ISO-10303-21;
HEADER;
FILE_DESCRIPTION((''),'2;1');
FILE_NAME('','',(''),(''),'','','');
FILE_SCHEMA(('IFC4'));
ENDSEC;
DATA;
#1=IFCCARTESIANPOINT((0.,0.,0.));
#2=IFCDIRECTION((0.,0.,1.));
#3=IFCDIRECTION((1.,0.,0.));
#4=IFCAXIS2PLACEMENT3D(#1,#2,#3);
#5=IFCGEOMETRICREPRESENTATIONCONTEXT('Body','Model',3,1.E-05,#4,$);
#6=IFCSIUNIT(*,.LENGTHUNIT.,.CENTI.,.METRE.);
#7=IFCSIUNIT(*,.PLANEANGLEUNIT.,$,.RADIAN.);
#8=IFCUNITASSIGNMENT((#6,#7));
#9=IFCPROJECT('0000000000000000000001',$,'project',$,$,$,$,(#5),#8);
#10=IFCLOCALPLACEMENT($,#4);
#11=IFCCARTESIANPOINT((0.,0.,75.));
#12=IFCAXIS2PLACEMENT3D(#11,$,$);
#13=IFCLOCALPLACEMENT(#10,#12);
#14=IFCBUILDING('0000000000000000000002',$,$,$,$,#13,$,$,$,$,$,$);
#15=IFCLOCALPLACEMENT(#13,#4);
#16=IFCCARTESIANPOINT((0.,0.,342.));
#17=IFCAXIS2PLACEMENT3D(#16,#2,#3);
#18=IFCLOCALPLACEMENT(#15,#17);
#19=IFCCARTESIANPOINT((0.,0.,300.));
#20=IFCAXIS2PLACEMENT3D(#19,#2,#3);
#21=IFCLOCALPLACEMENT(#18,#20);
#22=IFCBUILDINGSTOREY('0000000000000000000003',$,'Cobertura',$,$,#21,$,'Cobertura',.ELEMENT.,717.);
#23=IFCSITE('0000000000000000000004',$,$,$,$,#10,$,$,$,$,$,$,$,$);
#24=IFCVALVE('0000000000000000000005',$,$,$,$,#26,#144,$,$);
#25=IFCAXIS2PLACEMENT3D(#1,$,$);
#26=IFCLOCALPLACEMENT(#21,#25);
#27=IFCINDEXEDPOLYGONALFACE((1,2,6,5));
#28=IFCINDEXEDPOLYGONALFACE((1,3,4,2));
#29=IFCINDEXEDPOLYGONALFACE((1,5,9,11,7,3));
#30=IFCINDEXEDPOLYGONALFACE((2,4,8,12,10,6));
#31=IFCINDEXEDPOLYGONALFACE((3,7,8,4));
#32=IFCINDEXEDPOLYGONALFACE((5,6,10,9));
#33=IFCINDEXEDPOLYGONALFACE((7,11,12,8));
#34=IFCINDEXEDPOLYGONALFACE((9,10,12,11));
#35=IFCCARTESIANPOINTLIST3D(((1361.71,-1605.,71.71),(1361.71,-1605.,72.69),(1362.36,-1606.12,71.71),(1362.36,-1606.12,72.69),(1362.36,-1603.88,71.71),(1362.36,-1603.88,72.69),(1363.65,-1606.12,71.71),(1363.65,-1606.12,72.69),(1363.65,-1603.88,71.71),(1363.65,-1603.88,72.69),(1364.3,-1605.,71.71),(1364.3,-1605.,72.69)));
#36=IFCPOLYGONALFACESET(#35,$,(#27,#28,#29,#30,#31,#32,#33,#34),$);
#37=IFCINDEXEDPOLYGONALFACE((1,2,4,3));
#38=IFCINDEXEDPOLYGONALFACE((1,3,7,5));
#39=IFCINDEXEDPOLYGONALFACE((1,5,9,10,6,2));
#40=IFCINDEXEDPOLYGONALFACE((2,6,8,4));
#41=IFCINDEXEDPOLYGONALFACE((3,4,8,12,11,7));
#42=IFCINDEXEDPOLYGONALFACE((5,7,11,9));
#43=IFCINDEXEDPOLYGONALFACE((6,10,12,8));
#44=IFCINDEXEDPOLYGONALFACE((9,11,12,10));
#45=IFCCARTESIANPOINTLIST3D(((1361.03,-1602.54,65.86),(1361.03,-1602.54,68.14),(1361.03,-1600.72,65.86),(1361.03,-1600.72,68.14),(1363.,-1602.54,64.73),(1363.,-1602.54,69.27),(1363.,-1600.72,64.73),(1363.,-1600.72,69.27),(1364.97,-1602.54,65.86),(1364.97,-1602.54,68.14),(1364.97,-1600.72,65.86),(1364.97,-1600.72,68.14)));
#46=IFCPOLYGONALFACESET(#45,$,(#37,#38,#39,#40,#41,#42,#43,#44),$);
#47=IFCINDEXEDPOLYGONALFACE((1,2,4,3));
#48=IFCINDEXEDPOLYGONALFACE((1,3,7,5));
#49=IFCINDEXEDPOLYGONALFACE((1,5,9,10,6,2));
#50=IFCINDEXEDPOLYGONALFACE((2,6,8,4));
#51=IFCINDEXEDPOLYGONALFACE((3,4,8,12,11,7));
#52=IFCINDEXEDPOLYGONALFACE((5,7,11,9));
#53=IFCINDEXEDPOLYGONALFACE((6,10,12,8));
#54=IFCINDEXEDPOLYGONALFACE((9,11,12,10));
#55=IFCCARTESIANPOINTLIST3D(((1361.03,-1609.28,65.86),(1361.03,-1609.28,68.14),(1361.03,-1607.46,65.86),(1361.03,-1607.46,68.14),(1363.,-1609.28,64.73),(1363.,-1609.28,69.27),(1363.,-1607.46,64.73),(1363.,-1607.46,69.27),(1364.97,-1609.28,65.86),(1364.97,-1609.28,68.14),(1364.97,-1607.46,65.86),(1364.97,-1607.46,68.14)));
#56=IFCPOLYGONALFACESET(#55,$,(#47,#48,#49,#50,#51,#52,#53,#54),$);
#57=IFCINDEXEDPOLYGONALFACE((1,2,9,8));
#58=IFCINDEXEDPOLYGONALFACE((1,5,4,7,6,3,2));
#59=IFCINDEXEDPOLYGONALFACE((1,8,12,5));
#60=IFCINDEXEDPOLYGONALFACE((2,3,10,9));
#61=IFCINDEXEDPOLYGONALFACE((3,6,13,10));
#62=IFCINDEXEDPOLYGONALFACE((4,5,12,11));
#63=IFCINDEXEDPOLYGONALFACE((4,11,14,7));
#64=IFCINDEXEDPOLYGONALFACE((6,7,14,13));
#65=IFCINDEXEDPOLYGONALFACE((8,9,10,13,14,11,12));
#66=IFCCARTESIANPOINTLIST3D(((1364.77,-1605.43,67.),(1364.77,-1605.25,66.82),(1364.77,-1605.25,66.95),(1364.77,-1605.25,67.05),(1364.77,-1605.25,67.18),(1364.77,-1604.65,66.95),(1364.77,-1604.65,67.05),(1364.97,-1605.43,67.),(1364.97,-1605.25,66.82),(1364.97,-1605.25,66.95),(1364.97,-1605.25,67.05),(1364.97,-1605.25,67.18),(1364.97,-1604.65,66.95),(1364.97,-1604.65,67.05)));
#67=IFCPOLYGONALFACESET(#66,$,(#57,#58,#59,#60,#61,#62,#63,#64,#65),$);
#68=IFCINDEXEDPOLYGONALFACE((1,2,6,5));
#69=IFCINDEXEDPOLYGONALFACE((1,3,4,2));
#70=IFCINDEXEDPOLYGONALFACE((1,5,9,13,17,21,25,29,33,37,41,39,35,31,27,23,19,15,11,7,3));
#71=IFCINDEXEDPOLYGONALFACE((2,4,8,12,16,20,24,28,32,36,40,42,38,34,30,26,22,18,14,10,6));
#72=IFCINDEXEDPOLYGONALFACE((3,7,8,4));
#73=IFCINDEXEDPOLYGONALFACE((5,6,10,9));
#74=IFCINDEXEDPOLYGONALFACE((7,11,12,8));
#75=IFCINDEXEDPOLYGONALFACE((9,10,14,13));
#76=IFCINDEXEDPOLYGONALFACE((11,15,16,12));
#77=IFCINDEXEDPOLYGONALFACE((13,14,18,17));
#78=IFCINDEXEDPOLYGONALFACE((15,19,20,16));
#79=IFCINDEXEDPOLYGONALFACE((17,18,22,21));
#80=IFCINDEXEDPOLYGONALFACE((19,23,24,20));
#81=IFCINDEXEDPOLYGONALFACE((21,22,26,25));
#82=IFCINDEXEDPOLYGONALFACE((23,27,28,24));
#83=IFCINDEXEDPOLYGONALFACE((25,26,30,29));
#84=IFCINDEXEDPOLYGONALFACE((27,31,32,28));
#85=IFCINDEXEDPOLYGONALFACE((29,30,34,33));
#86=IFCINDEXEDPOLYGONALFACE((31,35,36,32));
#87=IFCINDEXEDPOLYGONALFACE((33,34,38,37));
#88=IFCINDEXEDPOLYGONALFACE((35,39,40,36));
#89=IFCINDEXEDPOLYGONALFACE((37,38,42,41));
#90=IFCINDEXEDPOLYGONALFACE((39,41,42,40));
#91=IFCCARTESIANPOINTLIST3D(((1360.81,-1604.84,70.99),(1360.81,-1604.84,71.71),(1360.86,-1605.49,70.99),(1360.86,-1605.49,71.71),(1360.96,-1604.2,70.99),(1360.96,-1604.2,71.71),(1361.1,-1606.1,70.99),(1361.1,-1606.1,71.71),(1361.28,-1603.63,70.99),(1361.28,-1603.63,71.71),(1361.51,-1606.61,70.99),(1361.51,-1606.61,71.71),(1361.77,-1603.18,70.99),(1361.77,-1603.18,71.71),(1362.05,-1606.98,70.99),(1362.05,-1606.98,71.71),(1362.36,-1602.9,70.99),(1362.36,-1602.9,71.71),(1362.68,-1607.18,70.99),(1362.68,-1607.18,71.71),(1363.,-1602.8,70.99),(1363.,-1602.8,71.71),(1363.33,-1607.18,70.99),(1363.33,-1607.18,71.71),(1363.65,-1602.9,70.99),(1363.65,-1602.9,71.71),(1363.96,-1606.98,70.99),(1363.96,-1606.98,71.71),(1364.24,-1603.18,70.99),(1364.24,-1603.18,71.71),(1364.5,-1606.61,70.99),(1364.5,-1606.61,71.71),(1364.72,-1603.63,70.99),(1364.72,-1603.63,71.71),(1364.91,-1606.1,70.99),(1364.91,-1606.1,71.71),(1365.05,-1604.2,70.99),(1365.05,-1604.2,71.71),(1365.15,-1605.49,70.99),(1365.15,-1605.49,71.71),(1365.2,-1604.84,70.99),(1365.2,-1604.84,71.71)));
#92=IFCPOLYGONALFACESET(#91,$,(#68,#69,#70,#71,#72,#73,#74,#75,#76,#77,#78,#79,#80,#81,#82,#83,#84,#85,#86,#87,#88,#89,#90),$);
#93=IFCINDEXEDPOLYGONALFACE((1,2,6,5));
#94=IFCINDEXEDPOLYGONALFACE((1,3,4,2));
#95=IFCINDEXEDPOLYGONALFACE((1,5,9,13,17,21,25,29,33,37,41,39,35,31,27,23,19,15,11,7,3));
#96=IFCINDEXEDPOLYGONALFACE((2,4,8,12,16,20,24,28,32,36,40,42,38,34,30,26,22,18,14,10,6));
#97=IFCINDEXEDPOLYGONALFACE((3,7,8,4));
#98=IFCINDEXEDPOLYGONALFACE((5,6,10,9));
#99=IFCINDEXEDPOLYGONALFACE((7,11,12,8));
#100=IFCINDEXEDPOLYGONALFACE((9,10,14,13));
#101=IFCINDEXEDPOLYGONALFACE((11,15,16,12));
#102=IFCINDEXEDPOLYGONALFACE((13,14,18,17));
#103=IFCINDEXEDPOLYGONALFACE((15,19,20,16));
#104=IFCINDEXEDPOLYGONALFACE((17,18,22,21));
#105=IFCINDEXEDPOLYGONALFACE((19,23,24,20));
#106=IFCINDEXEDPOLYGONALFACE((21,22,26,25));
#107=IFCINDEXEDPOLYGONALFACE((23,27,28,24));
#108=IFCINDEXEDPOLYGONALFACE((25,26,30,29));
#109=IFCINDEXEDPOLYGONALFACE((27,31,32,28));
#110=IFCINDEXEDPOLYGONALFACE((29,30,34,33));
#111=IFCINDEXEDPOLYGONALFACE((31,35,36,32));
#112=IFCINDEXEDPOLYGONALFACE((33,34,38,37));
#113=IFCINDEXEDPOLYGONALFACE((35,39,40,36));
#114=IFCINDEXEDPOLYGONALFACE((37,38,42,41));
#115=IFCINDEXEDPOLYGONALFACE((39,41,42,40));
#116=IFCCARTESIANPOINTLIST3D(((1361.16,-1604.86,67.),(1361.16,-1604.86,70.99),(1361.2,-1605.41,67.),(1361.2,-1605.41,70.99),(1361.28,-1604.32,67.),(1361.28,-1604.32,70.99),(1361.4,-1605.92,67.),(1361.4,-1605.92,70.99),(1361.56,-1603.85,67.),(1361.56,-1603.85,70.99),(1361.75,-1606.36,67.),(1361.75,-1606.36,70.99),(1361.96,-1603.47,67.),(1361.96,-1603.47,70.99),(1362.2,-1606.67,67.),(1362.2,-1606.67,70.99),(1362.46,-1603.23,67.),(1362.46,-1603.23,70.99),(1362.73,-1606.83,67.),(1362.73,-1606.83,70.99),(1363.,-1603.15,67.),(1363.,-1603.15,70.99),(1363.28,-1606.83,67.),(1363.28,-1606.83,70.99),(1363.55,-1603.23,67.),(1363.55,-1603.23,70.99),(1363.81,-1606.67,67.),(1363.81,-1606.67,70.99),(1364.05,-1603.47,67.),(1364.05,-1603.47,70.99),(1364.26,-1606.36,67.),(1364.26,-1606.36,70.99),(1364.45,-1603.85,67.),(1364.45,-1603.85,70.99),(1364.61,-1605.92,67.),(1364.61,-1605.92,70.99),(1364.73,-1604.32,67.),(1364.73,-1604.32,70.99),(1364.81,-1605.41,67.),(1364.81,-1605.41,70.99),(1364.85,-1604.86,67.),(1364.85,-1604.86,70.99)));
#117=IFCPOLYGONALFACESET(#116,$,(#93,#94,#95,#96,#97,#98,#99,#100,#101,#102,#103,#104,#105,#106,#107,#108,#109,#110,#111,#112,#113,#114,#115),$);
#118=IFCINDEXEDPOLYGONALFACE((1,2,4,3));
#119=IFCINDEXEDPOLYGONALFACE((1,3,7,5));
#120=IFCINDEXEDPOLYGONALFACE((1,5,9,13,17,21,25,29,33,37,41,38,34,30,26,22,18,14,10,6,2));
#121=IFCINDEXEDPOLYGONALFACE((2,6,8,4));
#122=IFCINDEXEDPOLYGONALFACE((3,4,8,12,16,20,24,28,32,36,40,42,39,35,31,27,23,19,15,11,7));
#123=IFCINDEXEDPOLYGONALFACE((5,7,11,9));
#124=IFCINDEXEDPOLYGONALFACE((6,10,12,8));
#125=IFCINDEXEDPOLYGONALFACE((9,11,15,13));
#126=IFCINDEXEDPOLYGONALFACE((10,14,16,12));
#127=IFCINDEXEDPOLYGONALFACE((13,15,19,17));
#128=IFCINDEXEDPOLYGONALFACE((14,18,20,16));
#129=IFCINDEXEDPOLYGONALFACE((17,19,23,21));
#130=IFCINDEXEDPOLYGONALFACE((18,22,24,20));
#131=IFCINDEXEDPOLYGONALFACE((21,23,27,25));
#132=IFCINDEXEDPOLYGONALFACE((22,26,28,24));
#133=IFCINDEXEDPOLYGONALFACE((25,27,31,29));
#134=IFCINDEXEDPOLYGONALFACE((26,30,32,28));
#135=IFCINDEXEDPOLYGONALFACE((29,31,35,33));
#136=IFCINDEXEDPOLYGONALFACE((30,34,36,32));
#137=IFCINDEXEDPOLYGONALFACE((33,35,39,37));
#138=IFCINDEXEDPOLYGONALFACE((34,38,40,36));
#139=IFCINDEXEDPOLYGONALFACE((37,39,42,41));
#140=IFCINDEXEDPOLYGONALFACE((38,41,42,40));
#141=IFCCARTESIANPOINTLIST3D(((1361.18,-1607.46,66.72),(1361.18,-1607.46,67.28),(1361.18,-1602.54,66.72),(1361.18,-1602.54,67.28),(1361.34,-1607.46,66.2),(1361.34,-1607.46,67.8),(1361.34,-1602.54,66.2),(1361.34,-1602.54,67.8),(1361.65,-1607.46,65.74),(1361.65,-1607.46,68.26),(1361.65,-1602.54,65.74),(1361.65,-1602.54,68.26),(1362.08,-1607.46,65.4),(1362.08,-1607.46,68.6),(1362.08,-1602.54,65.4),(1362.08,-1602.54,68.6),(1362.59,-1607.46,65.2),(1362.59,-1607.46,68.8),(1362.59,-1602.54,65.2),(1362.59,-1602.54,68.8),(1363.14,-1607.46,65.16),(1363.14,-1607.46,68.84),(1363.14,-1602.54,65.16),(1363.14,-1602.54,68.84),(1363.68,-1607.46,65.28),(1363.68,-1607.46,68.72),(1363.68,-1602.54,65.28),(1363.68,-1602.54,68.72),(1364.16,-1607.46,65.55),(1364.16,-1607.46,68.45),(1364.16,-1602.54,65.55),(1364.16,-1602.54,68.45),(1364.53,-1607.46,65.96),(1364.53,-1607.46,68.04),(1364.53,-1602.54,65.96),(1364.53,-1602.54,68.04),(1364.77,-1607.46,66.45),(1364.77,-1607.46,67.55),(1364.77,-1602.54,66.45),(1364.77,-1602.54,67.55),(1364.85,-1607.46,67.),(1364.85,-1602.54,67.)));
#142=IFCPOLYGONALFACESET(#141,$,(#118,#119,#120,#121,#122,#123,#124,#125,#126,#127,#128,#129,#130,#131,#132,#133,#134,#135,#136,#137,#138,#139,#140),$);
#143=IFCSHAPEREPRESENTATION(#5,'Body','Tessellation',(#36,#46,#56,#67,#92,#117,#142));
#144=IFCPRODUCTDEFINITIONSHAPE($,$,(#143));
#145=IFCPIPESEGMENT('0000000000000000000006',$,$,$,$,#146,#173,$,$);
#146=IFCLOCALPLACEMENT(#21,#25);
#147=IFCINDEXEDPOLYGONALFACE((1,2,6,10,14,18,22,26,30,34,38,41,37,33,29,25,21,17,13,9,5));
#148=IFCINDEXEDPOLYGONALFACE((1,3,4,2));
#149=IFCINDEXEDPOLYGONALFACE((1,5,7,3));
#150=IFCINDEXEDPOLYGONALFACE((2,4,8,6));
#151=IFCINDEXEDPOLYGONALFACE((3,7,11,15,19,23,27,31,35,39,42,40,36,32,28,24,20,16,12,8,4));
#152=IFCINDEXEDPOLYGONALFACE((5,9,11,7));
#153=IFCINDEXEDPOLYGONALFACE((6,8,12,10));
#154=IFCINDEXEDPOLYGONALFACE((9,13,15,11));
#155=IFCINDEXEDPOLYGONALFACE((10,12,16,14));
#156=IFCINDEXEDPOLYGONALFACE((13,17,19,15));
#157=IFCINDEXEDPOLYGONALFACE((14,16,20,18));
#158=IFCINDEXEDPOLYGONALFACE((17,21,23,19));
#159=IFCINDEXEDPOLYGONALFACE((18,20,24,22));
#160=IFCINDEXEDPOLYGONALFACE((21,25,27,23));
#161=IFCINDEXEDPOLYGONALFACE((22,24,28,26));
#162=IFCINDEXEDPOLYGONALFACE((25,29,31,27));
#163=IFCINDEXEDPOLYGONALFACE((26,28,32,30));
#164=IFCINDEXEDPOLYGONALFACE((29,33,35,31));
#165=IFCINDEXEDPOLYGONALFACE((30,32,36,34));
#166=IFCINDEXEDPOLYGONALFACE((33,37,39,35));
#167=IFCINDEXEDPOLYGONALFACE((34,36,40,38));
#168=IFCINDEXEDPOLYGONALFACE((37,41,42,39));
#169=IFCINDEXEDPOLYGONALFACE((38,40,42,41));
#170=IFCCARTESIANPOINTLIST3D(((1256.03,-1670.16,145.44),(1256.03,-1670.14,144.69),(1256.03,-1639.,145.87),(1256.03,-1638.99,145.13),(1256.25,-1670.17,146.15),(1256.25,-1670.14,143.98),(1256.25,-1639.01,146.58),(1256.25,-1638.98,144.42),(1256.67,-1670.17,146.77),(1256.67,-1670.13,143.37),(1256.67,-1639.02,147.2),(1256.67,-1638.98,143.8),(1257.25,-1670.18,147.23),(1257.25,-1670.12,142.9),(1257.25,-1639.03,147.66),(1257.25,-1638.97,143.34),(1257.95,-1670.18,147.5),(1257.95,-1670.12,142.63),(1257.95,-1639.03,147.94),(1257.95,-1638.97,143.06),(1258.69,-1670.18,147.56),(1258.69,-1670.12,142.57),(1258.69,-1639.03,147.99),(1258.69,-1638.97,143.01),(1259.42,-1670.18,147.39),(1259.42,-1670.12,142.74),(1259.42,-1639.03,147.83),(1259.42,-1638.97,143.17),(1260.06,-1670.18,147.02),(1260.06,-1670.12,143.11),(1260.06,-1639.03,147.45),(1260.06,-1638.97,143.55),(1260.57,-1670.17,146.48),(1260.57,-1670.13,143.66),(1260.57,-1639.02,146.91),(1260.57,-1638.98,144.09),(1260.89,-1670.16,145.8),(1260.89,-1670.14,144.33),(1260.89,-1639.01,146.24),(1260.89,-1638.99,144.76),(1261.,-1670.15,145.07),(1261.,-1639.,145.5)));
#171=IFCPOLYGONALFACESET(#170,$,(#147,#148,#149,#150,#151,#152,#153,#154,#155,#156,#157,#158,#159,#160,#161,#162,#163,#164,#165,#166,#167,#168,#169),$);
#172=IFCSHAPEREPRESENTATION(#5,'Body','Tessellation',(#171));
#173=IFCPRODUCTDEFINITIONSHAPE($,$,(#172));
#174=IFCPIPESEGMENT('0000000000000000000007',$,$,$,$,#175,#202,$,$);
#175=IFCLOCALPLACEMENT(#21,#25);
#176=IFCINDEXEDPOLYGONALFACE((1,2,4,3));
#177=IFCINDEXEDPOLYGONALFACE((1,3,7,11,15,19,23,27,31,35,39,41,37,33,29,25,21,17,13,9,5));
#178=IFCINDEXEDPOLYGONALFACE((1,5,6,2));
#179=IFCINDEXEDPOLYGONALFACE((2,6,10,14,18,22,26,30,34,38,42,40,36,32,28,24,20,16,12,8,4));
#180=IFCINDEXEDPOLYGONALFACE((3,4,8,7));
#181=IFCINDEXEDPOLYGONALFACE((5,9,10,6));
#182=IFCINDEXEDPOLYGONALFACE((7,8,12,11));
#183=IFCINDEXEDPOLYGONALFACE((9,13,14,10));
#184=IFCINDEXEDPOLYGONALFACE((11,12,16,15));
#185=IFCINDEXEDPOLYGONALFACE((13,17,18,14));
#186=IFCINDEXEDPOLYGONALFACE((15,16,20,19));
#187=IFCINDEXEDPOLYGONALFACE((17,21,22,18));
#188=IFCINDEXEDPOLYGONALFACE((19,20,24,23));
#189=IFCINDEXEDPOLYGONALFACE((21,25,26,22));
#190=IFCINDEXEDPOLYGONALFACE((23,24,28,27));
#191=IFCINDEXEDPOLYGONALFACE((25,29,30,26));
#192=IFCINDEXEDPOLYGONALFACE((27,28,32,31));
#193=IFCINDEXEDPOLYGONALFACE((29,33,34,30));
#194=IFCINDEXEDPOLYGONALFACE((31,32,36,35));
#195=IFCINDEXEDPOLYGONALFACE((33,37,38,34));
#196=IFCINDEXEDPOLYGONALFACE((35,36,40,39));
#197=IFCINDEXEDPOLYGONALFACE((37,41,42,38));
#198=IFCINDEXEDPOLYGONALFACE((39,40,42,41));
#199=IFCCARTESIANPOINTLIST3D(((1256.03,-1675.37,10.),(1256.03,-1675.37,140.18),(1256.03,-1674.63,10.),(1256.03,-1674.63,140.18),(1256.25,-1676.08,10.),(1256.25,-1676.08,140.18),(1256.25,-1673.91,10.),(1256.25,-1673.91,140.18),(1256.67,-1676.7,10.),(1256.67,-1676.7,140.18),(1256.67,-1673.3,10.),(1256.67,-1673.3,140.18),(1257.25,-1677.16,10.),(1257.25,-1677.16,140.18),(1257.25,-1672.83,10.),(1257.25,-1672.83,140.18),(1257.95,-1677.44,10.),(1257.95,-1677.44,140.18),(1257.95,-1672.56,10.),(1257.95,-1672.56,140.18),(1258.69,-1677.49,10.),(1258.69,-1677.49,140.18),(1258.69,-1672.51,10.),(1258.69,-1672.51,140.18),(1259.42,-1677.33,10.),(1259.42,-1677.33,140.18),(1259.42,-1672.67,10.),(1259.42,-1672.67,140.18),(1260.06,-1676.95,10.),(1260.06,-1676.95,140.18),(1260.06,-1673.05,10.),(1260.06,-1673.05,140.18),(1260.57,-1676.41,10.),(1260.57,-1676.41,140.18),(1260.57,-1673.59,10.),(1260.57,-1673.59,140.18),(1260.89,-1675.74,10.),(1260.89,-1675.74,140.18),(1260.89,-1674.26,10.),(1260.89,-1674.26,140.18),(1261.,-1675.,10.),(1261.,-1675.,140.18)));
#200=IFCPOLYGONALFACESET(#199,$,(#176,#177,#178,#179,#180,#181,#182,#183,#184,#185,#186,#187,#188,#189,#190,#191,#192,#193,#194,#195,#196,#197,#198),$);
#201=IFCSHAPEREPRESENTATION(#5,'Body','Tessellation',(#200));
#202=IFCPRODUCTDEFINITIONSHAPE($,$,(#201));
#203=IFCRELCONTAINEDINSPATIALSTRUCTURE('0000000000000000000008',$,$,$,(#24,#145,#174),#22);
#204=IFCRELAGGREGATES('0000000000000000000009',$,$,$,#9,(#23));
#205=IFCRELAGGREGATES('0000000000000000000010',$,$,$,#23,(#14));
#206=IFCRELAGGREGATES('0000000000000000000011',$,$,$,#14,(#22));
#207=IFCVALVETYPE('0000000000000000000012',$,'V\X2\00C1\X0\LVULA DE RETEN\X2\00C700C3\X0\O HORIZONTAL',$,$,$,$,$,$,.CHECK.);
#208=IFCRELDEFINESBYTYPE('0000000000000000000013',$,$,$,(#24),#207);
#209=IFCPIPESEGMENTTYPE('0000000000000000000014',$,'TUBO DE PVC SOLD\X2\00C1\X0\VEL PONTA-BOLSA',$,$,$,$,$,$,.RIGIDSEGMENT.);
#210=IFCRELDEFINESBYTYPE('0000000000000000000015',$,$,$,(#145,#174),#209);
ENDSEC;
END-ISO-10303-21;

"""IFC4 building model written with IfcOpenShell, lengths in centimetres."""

from ifc_helpers import new_model, si_unit, frame, origin_with_axes, origin_2d_with_axis, place, context, project, spatial, polyline, circle, outline, extrude, source, transform, mapped, type_object, element, save


model = new_model("IFC4")

# Units and contexts
model_context = context("Model", 3, precision=1e-05, world=origin_with_axes(), identifier="Body")
ifc_project = project(units=[si_unit("LENGTHUNIT", "METRE", prefix="CENTI"), si_unit("PLANEANGLEUNIT", "RADIAN")], contexts=[model_context])

# Site, building, storey
site_placement = place(None, origin_with_axes())
site = spatial("IfcSite", under=ifc_project, at=site_placement)
building_placement = place(site_placement, frame((0.0, 0.0, 75.0)))
building = spatial("IfcBuilding", under=site, at=building_placement)
placement_1 = place(building_placement, origin_with_axes())
placement_2 = place(placement_1, frame((0.0, 0.0, 342.0), z_axis=(0.0, 0.0, 1.0), x_axis=(1.0, 0.0, 0.0)))
storey_placement = place(placement_2, frame((0.0, 0.0, 300.0), z_axis=(0.0, 0.0, 1.0), x_axis=(1.0, 0.0, 0.0)))
storey = spatial("IfcBuildingStorey", under=building, at=storey_placement, Name="Cobertura", LongName="Cobertura", CompositionType="ELEMENT", Elevation=717.0)

# Valve
valve_type_1 = type_object("IfcValveType", Name="VÁLVULA DE RETENÇÃO HORIZONTAL", PredefinedType="CHECK")
shared_shape_1 = source(origin_with_axes(), model_context, "Body", "SolidModel", [
    extrude(outline(polyline([(-0.65, -1.12), (0.65, -1.12), (1.29, 0.0), (0.65, 1.12), (-0.65, 1.12), (-1.29, 0.0), (-0.65, -1.12)])), frame((0.0, 0.0, 4.71), z_axis=(0.0, 0.0, 1.0), x_axis=(0.0, -1.0, 0.0)), (0.0, 0.0, 1.0), 0.98),
    extrude(outline(polyline([(-1.14, -1.97), (1.14, -1.97), (2.27, 0.0), (1.14, 1.97), (-1.14, 1.97), (-2.27, 0.0), (-1.14, -1.97)])), frame((2.46, 0.0, 0.0), z_axis=(1.0, 0.0, 0.0), x_axis=(0.0, 0.0, -1.0)), (0.0, 0.0, 1.0), 1.82),
    extrude(outline(polyline([(-1.14, -1.97), (1.14, -1.97), (2.27, 0.0), (1.14, 1.97), (-1.14, 1.97), (-2.27, 0.0), (-1.14, -1.97)])), frame((-4.28, 0.0, 0.0), z_axis=(1.0, 0.0, 0.0), x_axis=(0.0, 0.0, -1.0)), (0.0, 0.0, 1.0), 1.82),
    extrude(outline(polyline([(0.05, 0.15), (0.18, 0.15), (0.0, 0.33), (-0.18, 0.15), (-0.05, 0.15), (-0.05, -0.45), (0.05, -0.45), (0.05, 0.15)])), frame((-0.1, -1.97, 0.0), z_axis=(0.0, 1.0, 0.0), x_axis=(0.0, 0.0, -1.0)), (0.0, 0.0, 1.0), 0.2),
    extrude(circle(Radius=2.2, at=origin_2d_with_axis()), frame((0.0, 0.0, 3.99), z_axis=(0.0, 0.0, 1.0), x_axis=(1.0, 0.0, 0.0)), (0.0, 0.0, 1.0), 0.72),
    extrude(circle(Radius=1.85, at=origin_2d_with_axis()), origin_with_axes(), (0.0, 0.0, 1.0), 3.99),
    extrude(circle(Radius=1.85, at=origin_2d_with_axis()), frame((-2.46, 0.0, 0.0), z_axis=(1.0, 0.0, 0.0), x_axis=(0.0, -1.0, 0.0)), (0.0, 0.0, 1.0), 4.92),
])
valve_1_placement = place(storey_placement, frame((1363.0, -1605.0, 67.0), z_axis=(0.0, 0.0, 1.0), x_axis=(0.0, 1.0, 0.0)))
element("IfcValve", 1, at=valve_1_placement, inside=storey, type_object=valve_type_1, context=model_context, shape_type="MappedRepresentation", body=[
    mapped(shared_shape_1, transform((0.0, 0.0, 0.0), scale=1.0)),
])

# Pipe segments
pipe_segment_type_1 = type_object("IfcPipeSegmentType", Name="TUBO DE PVC SOLDÁVEL PONTA-BOLSA", PredefinedType="RIGIDSEGMENT")
pipe_segment_1_placement = place(storey_placement, frame((1258.5, -1654.57, 148.0), z_axis=(0.0, 0.0, 1.0), x_axis=(1.0, 0.0, 0.0)))
element("IfcPipeSegment", 2, at=pipe_segment_1_placement, inside=storey, type_object=pipe_segment_type_1, context=model_context, shape_type="SolidModel", body=[
    extrude(circle(Radius=2.5, at=origin_2d_with_axis()), frame((0.0, 15.58, -2.5), z_axis=(0.0, -1.0, -0.013888), x_axis=(1.0, 0.0, 0.0)), (0.0, 0.0, 1.0), 31.15),
])
pipe_segment_2_placement = place(storey_placement, frame((1258.5, -1675.0, 140.18), z_axis=(0.0, 0.0, 1.0), x_axis=(1.0, 0.0, 0.0)))
element("IfcPipeSegment", 3, at=pipe_segment_2_placement, inside=storey, type_object=pipe_segment_type_1, context=model_context, shape_type="SolidModel", body=[
    extrude(circle(Radius=2.5, at=origin_2d_with_axis()), frame((0.0, 0.0, 0.0), z_axis=(0.0, 0.0, -1.0), x_axis=(1.0, 0.0, 0.0)), (0.0, 0.0, 1.0), 130.18),
])

save(model, "model.ifc")
